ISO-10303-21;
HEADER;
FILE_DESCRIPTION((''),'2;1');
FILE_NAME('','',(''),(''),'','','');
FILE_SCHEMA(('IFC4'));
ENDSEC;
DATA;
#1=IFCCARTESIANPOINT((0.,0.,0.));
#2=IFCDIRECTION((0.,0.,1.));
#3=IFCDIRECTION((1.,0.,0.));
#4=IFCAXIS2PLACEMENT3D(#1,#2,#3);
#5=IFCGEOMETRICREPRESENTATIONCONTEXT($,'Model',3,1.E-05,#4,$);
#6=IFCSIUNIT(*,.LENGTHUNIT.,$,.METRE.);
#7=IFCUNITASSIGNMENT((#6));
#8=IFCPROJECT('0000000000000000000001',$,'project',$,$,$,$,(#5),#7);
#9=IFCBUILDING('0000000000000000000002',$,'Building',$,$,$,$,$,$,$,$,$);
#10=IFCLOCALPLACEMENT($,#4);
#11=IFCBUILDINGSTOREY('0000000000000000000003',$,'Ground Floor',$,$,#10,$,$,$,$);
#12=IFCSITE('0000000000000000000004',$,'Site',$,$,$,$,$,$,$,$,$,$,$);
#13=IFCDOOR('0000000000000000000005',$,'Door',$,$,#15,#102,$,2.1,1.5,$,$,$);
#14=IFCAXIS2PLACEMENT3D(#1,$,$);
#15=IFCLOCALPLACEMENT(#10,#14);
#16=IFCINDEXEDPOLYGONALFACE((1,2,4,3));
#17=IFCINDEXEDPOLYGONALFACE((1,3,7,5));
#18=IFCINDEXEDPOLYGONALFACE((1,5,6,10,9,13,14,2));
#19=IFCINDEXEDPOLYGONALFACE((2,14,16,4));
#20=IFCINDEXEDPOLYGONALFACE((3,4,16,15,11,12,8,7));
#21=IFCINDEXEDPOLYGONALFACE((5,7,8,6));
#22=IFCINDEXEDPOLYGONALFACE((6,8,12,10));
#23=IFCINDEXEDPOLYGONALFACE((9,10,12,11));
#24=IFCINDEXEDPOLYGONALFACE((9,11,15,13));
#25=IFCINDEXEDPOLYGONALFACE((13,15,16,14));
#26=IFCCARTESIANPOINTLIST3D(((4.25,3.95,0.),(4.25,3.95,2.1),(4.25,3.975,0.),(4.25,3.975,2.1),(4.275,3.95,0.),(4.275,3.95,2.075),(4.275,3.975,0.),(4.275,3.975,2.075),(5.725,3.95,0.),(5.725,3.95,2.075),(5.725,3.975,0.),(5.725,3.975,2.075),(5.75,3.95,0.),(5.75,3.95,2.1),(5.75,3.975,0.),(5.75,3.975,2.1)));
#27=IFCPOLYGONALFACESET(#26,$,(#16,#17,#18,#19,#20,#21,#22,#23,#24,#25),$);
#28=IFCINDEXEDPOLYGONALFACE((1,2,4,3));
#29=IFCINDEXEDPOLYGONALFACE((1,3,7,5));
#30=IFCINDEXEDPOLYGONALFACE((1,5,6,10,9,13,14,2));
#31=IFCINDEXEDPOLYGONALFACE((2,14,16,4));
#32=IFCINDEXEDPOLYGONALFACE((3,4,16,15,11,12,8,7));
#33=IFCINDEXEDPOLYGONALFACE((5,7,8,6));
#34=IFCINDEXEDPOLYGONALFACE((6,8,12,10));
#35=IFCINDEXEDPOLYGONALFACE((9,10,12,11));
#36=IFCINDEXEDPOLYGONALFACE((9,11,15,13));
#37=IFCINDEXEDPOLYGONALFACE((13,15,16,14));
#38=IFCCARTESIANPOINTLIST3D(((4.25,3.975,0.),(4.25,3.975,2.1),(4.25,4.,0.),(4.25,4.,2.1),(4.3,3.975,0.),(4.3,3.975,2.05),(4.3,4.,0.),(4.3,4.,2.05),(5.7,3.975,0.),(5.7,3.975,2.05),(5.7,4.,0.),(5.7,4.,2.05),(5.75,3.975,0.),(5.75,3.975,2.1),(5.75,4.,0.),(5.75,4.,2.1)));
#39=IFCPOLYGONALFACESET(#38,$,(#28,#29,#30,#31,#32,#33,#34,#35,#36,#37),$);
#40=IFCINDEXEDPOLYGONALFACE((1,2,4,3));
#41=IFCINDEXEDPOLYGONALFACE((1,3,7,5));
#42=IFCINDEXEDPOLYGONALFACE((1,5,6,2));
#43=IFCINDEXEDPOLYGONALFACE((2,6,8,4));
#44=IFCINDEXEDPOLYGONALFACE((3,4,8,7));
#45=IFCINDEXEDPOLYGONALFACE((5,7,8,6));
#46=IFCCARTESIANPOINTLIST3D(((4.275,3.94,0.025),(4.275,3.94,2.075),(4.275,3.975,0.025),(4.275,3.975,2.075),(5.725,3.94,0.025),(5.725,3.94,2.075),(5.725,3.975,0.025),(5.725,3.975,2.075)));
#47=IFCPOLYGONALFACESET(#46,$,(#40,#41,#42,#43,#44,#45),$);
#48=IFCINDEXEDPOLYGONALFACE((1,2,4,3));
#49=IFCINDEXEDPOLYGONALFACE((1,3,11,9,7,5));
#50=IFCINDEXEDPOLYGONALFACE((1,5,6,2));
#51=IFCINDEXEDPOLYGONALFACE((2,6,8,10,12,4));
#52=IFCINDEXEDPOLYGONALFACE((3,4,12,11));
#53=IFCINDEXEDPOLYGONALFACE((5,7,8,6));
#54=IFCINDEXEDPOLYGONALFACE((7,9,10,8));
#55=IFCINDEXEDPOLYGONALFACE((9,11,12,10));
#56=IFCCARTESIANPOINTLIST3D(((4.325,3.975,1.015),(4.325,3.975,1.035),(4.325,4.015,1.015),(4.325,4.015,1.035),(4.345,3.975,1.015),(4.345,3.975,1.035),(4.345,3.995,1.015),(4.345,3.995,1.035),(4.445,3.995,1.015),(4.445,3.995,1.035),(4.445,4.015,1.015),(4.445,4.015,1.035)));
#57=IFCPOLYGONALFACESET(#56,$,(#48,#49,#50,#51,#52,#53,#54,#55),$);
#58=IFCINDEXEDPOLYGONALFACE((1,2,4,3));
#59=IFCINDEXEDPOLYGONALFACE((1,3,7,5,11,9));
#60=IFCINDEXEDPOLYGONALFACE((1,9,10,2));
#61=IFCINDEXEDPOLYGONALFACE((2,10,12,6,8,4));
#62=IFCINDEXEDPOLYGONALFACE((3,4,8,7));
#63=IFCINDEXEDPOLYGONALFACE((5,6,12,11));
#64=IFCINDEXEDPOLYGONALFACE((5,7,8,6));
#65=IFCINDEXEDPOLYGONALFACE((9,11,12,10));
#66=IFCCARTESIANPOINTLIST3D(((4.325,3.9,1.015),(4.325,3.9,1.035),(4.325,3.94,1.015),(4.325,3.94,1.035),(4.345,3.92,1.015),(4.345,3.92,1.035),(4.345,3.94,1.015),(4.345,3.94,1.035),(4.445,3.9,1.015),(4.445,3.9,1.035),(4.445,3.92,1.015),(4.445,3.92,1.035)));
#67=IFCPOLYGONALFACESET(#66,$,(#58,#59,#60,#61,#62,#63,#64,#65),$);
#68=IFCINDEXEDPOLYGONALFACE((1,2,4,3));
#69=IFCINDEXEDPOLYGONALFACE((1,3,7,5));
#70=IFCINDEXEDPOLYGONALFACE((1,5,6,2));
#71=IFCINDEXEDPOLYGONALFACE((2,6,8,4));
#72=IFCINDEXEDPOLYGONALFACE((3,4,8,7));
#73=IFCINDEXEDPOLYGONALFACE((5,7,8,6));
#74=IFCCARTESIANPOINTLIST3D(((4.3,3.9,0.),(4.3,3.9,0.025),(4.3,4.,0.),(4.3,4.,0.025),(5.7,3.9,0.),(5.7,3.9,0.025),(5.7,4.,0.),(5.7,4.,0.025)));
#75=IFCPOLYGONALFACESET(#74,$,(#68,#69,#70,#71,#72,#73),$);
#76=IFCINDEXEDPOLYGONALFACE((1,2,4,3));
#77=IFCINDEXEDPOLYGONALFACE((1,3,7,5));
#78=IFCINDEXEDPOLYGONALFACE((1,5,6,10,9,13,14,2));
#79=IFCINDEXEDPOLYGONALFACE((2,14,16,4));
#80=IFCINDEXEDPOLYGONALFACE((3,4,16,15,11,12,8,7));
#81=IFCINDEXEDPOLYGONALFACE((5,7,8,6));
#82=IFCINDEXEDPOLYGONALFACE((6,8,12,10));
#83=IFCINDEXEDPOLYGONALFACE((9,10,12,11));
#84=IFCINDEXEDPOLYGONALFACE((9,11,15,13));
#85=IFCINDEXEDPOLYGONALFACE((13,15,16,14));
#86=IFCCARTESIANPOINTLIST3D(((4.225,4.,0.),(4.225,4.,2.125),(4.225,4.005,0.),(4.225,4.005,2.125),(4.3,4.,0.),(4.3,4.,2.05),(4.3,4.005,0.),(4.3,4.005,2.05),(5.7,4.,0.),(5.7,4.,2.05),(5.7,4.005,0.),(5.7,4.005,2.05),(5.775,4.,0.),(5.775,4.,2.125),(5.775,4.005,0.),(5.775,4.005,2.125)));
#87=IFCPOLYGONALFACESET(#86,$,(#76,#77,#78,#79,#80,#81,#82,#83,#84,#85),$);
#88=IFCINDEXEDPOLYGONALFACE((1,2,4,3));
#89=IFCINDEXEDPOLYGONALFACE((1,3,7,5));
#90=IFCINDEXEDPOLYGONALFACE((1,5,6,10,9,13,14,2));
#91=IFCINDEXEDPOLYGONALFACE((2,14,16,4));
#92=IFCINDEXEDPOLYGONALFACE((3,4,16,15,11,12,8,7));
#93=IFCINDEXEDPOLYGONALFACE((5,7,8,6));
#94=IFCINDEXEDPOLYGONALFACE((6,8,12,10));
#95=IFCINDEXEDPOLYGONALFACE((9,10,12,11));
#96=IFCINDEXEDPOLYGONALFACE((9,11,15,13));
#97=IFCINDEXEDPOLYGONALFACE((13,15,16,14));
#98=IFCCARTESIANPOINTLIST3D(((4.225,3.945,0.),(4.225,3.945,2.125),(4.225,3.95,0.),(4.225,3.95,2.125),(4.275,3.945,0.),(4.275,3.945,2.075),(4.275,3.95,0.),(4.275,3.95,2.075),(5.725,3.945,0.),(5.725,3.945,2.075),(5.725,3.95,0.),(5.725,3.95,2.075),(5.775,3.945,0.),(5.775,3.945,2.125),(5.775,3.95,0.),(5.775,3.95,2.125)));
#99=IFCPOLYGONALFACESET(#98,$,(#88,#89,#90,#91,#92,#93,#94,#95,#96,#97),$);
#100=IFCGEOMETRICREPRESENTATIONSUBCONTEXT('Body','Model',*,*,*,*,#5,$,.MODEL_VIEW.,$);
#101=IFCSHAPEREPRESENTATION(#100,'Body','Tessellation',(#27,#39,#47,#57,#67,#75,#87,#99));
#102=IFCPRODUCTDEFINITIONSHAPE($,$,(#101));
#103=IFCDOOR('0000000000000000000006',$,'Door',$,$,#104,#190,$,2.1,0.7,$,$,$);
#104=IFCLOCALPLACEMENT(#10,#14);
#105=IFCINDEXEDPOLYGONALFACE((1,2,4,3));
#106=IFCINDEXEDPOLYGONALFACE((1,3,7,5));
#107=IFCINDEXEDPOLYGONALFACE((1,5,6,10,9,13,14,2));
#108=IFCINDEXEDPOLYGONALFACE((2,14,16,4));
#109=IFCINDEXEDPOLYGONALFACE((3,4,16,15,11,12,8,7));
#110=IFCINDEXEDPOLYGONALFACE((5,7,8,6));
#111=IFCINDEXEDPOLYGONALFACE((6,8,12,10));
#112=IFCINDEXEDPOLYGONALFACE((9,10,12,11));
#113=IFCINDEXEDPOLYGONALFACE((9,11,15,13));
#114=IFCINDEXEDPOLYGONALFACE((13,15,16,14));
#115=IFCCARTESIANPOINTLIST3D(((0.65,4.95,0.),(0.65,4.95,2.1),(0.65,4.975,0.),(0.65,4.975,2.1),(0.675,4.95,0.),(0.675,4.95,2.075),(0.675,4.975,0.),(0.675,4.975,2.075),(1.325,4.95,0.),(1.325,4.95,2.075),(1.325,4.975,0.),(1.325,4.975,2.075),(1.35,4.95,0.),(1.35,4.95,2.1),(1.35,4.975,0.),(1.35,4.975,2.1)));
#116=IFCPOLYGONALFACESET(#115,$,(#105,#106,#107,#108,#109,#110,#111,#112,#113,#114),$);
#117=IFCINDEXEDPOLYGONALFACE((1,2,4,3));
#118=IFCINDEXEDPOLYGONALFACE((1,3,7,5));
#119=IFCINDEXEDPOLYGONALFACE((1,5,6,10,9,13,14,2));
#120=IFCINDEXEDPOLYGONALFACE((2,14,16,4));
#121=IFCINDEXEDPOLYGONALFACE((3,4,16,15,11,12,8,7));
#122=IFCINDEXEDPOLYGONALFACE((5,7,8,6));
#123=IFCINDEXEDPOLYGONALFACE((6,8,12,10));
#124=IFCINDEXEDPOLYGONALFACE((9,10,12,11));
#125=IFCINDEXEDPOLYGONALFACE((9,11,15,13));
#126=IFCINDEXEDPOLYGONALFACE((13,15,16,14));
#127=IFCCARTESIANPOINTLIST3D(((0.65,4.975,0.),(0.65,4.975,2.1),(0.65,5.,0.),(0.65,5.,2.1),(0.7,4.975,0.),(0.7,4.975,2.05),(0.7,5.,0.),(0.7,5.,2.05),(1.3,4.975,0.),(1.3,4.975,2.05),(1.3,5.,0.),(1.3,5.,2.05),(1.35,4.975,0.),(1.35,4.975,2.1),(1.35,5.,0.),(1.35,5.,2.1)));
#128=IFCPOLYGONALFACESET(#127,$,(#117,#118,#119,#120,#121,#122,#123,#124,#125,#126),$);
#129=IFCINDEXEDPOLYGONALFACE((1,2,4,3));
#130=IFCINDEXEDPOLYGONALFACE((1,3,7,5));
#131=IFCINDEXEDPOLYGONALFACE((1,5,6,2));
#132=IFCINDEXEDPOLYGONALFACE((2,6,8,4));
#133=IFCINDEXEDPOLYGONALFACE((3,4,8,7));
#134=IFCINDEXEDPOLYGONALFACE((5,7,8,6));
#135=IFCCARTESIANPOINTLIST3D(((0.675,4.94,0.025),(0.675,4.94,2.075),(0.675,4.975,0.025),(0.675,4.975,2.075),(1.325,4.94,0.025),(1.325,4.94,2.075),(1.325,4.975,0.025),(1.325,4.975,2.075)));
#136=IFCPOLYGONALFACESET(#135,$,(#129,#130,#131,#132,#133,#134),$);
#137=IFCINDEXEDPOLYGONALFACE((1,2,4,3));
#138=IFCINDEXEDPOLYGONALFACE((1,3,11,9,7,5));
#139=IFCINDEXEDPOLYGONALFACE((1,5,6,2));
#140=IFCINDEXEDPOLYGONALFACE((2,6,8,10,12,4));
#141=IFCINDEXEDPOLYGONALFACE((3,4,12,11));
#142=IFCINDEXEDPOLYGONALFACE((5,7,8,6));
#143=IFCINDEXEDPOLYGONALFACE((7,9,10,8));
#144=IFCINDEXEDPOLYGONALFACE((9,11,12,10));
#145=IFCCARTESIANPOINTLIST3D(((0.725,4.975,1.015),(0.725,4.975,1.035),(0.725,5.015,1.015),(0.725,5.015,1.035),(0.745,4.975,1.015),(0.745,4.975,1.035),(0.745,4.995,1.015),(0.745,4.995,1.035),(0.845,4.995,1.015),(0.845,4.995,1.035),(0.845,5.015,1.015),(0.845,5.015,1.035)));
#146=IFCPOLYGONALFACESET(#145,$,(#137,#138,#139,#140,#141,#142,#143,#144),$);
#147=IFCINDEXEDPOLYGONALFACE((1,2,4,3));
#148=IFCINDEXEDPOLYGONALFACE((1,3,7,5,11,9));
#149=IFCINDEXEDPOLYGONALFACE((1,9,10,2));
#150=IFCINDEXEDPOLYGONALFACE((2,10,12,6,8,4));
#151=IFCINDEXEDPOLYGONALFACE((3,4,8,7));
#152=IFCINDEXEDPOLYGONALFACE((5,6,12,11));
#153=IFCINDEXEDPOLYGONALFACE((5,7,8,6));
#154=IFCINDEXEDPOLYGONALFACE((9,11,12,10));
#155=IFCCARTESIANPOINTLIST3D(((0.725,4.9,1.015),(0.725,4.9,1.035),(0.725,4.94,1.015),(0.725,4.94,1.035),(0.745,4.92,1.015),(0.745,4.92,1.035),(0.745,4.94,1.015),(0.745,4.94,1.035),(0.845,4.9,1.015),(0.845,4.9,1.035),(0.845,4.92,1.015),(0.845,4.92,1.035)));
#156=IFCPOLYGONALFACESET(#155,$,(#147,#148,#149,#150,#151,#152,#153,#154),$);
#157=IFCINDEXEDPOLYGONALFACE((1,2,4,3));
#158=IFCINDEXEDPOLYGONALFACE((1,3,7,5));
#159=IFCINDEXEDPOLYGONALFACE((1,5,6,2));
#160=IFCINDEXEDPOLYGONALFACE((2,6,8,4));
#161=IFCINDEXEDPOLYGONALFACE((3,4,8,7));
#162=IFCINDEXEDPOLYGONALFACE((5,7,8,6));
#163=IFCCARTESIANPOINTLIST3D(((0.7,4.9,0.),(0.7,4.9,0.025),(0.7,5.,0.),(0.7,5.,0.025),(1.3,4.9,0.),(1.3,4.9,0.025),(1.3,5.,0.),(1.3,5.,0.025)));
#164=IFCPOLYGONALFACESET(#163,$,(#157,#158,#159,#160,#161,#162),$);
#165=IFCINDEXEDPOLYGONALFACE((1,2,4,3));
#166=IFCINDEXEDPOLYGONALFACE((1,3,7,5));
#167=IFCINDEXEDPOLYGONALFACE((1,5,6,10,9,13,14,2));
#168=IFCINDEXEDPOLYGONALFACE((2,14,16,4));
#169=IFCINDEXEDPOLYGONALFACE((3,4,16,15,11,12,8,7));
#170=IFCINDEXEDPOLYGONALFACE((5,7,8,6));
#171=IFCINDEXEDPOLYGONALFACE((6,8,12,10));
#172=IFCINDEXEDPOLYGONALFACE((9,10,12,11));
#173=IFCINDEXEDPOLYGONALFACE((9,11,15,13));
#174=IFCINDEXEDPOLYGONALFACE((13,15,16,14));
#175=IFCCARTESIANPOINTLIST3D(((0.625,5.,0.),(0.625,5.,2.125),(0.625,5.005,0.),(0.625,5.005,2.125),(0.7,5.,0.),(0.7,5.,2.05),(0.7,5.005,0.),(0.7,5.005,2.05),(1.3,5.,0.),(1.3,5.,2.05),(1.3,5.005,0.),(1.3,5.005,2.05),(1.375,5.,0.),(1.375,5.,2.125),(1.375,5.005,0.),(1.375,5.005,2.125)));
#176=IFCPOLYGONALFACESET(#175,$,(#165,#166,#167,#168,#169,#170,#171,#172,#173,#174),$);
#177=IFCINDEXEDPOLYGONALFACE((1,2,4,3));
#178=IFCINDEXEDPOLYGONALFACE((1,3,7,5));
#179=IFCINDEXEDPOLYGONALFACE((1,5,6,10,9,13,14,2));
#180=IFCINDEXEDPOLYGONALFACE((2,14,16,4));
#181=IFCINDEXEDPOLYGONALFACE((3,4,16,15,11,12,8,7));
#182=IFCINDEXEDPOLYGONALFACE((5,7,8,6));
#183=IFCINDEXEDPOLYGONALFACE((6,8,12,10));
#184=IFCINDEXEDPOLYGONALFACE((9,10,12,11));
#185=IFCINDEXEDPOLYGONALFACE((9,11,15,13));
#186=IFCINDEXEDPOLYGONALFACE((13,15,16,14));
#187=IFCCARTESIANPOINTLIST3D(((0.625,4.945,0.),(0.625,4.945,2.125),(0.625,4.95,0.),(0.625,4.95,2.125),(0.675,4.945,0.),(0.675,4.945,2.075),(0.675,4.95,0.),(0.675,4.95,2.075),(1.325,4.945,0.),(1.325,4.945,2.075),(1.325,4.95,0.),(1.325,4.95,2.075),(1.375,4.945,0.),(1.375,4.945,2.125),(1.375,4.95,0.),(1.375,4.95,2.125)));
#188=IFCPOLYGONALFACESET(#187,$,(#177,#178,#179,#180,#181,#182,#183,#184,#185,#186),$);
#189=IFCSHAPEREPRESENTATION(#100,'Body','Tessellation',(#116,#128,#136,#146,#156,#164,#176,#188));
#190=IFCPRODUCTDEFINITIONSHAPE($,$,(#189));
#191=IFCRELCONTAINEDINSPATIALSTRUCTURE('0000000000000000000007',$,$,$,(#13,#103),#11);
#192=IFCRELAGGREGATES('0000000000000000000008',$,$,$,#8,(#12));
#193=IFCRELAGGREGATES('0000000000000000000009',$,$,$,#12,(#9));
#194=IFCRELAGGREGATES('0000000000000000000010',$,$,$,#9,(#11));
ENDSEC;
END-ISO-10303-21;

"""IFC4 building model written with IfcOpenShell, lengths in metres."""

from ifc_helpers import new_model, si_unit, frame, origin_with_axes, place, context, subcontext, project, spatial, line, indexed_curve, outline, extrude, element, save


model = new_model("IFC4")

# Units and contexts
model_context = context("Model", 3, precision=1e-05, world=origin_with_axes())
body_context = subcontext(model_context, "Body", "Model", "MODEL_VIEW")
ifc_project = project(units=[si_unit("LENGTHUNIT", "METRE")], contexts=[model_context])

# Site, building, storey
site = spatial("IfcSite", under=ifc_project, Name="Site")
building = spatial("IfcBuilding", under=site, Name="Building")
storey_placement = place(None, origin_with_axes())
storey = spatial("IfcBuildingStorey", under=building, at=storey_placement, Name="Ground Floor")

# Doors
door_1_placement = place(storey_placement, frame((5.75, 4.0, 0.0), z_axis=(0.0, 0.0, 1.0), x_axis=(-1.0, 0.0, 0.0)))
element("IfcDoor", 1, at=door_1_placement, inside=storey, Name="Door", OverallHeight=2.1, OverallWidth=1.5, context=body_context, shape_type="SweptSolid", body=[
    extrude(outline(indexed_curve([(0.0, 0.0), (0.0, 2.1), (1.5, 2.1), (1.5, 0.0), (1.475, 0.0), (1.475, 2.075), (0.025, 2.075), (0.025, 0.0)], segments=[line(1, 2, 3, 4, 5, 6, 7, 8, 1)])), frame((0.0, 0.025, 0.0), z_axis=(0.0, -1.0, 0.0), x_axis=(1.0, 0.0, 0.0)), (0.0, 0.0, -1.0), 0.025),
    extrude(outline(indexed_curve([(0.0, 0.0), (0.0, 2.1), (1.5, 2.1), (1.5, 0.0), (1.45, 0.0), (1.45, 2.05), (0.05, 2.05), (0.05, 0.0)], segments=[line(1, 2, 3, 4, 5, 6, 7, 8, 1)])), frame((0.0, 0.0, 0.0), z_axis=(0.0, -1.0, 0.0), x_axis=(1.0, 0.0, 0.0)), (0.0, 0.0, -1.0), 0.025),
    extrude(outline(indexed_curve([(0.0, 0.0), (1.45, 0.0), (1.45, 0.035), (0.0, 0.035)], segments=[line(1, 2, 3, 4, 1)])), frame((0.025, 0.025, 0.025), z_axis=(0.0, 0.0, 1.0), x_axis=(1.0, 0.0, 0.0)), (0.0, 0.0, 1.0), 2.05),
    extrude(outline(indexed_curve([(0.0, 0.0), (0.0, -0.04), (-0.12, -0.04), (-0.12, -0.02), (-0.02, -0.02), (-0.02, 0.0)], segments=[line(1, 2, 3, 4, 5, 6, 1)])), frame((1.425, 0.025, 1.015), z_axis=(0.0, 0.0, 1.0), x_axis=(1.0, 0.0, 0.0)), (0.0, 0.0, 1.0), 0.02),
    extrude(outline(indexed_curve([(0.0, 0.0), (0.0, 0.04), (-0.12, 0.04), (-0.12, 0.02), (-0.02, 0.02), (-0.02, 0.0)], segments=[line(1, 2, 3, 4, 5, 6, 1)])), frame((1.425, 0.06, 1.015), z_axis=(0.0, 0.0, 1.0), x_axis=(1.0, 0.0, 0.0)), (0.0, 0.0, 1.0), 0.02),
    extrude(outline(indexed_curve([(0.0, 0.0), (1.4, 0.0), (1.4, 0.1), (0.0, 0.1)], segments=[line(1, 2, 3, 4, 1)])), frame((0.05, 0.0, 0.0), z_axis=(0.0, 0.0, 1.0), x_axis=(1.0, 0.0, 0.0)), (0.0, 0.0, 1.0), 0.025),
    extrude(outline(indexed_curve([(0.0, 0.0), (0.0, 2.125), (1.55, 2.125), (1.55, 0.0), (1.475, 0.0), (1.475, 2.05), (0.075, 2.05), (0.075, 0.0)], segments=[line(1, 2, 3, 4, 5, 6, 7, 8, 1)])), frame((-0.025, -0.005, 0.0), z_axis=(0.0, -1.0, 0.0), x_axis=(1.0, 0.0, 0.0)), (0.0, 0.0, -1.0), 0.005),
    extrude(outline(indexed_curve([(0.0, 0.0), (0.0, 2.125), (1.55, 2.125), (1.55, 0.0), (1.5, 0.0), (1.5, 2.075), (0.05, 2.075), (0.05, 0.0)], segments=[line(1, 2, 3, 4, 5, 6, 7, 8, 1)])), frame((-0.025, 0.05, 0.0), z_axis=(0.0, -1.0, 0.0), x_axis=(1.0, 0.0, 0.0)), (0.0, 0.0, -1.0), 0.005),
])
door_2_placement = place(storey_placement, frame((1.35, 5.0, 0.0), z_axis=(0.0, 0.0, 1.0), x_axis=(-1.0, 0.0, 0.0)))
element("IfcDoor", 2, at=door_2_placement, inside=storey, Name="Door", OverallHeight=2.1, OverallWidth=0.7, context=body_context, shape_type="SweptSolid", body=[
    extrude(outline(indexed_curve([(0.0, 0.0), (0.0, 2.1), (0.7, 2.1), (0.7, 0.0), (0.675, 0.0), (0.675, 2.075), (0.025, 2.075), (0.025, 0.0)], segments=[line(1, 2, 3, 4, 5, 6, 7, 8, 1)])), frame((0.0, 0.025, 0.0), z_axis=(0.0, -1.0, 0.0), x_axis=(1.0, 0.0, 0.0)), (0.0, 0.0, -1.0), 0.025),
    extrude(outline(indexed_curve([(0.0, 0.0), (0.0, 2.1), (0.7, 2.1), (0.7, 0.0), (0.65, 0.0), (0.65, 2.05), (0.05, 2.05), (0.05, 0.0)], segments=[line(1, 2, 3, 4, 5, 6, 7, 8, 1)])), frame((0.0, 0.0, 0.0), z_axis=(0.0, -1.0, 0.0), x_axis=(1.0, 0.0, 0.0)), (0.0, 0.0, -1.0), 0.025),
    extrude(outline(indexed_curve([(0.0, 0.0), (0.65, 0.0), (0.65, 0.035), (0.0, 0.035)], segments=[line(1, 2, 3, 4, 1)])), frame((0.025, 0.025, 0.025), z_axis=(0.0, 0.0, 1.0), x_axis=(1.0, 0.0, 0.0)), (0.0, 0.0, 1.0), 2.05),
    extrude(outline(indexed_curve([(0.0, 0.0), (0.0, -0.04), (-0.12, -0.04), (-0.12, -0.02), (-0.02, -0.02), (-0.02, 0.0)], segments=[line(1, 2, 3, 4, 5, 6, 1)])), frame((0.625, 0.025, 1.015), z_axis=(0.0, 0.0, 1.0), x_axis=(1.0, 0.0, 0.0)), (0.0, 0.0, 1.0), 0.02),
    extrude(outline(indexed_curve([(0.0, 0.0), (0.0, 0.04), (-0.12, 0.04), (-0.12, 0.02), (-0.02, 0.02), (-0.02, 0.0)], segments=[line(1, 2, 3, 4, 5, 6, 1)])), frame((0.625, 0.06, 1.015), z_axis=(0.0, 0.0, 1.0), x_axis=(1.0, 0.0, 0.0)), (0.0, 0.0, 1.0), 0.02),
    extrude(outline(indexed_curve([(0.0, 0.0), (0.6, 0.0), (0.6, 0.1), (0.0, 0.1)], segments=[line(1, 2, 3, 4, 1)])), frame((0.05, 0.0, 0.0), z_axis=(0.0, 0.0, 1.0), x_axis=(1.0, 0.0, 0.0)), (0.0, 0.0, 1.0), 0.025),
    extrude(outline(indexed_curve([(0.0, 0.0), (0.0, 2.125), (0.75, 2.125), (0.75, 0.0), (0.675, 0.0), (0.675, 2.05), (0.075, 2.05), (0.075, 0.0)], segments=[line(1, 2, 3, 4, 5, 6, 7, 8, 1)])), frame((-0.025, -0.005, 0.0), z_axis=(0.0, -1.0, 0.0), x_axis=(1.0, 0.0, 0.0)), (0.0, 0.0, -1.0), 0.005),
    extrude(outline(indexed_curve([(0.0, 0.0), (0.0, 2.125), (0.75, 2.125), (0.75, 0.0), (0.7, 0.0), (0.7, 2.075), (0.05, 2.075), (0.05, 0.0)], segments=[line(1, 2, 3, 4, 5, 6, 7, 8, 1)])), frame((-0.025, 0.05, 0.0), z_axis=(0.0, -1.0, 0.0), x_axis=(1.0, 0.0, 0.0)), (0.0, 0.0, -1.0), 0.005),
])

save(model, "model.ifc")
